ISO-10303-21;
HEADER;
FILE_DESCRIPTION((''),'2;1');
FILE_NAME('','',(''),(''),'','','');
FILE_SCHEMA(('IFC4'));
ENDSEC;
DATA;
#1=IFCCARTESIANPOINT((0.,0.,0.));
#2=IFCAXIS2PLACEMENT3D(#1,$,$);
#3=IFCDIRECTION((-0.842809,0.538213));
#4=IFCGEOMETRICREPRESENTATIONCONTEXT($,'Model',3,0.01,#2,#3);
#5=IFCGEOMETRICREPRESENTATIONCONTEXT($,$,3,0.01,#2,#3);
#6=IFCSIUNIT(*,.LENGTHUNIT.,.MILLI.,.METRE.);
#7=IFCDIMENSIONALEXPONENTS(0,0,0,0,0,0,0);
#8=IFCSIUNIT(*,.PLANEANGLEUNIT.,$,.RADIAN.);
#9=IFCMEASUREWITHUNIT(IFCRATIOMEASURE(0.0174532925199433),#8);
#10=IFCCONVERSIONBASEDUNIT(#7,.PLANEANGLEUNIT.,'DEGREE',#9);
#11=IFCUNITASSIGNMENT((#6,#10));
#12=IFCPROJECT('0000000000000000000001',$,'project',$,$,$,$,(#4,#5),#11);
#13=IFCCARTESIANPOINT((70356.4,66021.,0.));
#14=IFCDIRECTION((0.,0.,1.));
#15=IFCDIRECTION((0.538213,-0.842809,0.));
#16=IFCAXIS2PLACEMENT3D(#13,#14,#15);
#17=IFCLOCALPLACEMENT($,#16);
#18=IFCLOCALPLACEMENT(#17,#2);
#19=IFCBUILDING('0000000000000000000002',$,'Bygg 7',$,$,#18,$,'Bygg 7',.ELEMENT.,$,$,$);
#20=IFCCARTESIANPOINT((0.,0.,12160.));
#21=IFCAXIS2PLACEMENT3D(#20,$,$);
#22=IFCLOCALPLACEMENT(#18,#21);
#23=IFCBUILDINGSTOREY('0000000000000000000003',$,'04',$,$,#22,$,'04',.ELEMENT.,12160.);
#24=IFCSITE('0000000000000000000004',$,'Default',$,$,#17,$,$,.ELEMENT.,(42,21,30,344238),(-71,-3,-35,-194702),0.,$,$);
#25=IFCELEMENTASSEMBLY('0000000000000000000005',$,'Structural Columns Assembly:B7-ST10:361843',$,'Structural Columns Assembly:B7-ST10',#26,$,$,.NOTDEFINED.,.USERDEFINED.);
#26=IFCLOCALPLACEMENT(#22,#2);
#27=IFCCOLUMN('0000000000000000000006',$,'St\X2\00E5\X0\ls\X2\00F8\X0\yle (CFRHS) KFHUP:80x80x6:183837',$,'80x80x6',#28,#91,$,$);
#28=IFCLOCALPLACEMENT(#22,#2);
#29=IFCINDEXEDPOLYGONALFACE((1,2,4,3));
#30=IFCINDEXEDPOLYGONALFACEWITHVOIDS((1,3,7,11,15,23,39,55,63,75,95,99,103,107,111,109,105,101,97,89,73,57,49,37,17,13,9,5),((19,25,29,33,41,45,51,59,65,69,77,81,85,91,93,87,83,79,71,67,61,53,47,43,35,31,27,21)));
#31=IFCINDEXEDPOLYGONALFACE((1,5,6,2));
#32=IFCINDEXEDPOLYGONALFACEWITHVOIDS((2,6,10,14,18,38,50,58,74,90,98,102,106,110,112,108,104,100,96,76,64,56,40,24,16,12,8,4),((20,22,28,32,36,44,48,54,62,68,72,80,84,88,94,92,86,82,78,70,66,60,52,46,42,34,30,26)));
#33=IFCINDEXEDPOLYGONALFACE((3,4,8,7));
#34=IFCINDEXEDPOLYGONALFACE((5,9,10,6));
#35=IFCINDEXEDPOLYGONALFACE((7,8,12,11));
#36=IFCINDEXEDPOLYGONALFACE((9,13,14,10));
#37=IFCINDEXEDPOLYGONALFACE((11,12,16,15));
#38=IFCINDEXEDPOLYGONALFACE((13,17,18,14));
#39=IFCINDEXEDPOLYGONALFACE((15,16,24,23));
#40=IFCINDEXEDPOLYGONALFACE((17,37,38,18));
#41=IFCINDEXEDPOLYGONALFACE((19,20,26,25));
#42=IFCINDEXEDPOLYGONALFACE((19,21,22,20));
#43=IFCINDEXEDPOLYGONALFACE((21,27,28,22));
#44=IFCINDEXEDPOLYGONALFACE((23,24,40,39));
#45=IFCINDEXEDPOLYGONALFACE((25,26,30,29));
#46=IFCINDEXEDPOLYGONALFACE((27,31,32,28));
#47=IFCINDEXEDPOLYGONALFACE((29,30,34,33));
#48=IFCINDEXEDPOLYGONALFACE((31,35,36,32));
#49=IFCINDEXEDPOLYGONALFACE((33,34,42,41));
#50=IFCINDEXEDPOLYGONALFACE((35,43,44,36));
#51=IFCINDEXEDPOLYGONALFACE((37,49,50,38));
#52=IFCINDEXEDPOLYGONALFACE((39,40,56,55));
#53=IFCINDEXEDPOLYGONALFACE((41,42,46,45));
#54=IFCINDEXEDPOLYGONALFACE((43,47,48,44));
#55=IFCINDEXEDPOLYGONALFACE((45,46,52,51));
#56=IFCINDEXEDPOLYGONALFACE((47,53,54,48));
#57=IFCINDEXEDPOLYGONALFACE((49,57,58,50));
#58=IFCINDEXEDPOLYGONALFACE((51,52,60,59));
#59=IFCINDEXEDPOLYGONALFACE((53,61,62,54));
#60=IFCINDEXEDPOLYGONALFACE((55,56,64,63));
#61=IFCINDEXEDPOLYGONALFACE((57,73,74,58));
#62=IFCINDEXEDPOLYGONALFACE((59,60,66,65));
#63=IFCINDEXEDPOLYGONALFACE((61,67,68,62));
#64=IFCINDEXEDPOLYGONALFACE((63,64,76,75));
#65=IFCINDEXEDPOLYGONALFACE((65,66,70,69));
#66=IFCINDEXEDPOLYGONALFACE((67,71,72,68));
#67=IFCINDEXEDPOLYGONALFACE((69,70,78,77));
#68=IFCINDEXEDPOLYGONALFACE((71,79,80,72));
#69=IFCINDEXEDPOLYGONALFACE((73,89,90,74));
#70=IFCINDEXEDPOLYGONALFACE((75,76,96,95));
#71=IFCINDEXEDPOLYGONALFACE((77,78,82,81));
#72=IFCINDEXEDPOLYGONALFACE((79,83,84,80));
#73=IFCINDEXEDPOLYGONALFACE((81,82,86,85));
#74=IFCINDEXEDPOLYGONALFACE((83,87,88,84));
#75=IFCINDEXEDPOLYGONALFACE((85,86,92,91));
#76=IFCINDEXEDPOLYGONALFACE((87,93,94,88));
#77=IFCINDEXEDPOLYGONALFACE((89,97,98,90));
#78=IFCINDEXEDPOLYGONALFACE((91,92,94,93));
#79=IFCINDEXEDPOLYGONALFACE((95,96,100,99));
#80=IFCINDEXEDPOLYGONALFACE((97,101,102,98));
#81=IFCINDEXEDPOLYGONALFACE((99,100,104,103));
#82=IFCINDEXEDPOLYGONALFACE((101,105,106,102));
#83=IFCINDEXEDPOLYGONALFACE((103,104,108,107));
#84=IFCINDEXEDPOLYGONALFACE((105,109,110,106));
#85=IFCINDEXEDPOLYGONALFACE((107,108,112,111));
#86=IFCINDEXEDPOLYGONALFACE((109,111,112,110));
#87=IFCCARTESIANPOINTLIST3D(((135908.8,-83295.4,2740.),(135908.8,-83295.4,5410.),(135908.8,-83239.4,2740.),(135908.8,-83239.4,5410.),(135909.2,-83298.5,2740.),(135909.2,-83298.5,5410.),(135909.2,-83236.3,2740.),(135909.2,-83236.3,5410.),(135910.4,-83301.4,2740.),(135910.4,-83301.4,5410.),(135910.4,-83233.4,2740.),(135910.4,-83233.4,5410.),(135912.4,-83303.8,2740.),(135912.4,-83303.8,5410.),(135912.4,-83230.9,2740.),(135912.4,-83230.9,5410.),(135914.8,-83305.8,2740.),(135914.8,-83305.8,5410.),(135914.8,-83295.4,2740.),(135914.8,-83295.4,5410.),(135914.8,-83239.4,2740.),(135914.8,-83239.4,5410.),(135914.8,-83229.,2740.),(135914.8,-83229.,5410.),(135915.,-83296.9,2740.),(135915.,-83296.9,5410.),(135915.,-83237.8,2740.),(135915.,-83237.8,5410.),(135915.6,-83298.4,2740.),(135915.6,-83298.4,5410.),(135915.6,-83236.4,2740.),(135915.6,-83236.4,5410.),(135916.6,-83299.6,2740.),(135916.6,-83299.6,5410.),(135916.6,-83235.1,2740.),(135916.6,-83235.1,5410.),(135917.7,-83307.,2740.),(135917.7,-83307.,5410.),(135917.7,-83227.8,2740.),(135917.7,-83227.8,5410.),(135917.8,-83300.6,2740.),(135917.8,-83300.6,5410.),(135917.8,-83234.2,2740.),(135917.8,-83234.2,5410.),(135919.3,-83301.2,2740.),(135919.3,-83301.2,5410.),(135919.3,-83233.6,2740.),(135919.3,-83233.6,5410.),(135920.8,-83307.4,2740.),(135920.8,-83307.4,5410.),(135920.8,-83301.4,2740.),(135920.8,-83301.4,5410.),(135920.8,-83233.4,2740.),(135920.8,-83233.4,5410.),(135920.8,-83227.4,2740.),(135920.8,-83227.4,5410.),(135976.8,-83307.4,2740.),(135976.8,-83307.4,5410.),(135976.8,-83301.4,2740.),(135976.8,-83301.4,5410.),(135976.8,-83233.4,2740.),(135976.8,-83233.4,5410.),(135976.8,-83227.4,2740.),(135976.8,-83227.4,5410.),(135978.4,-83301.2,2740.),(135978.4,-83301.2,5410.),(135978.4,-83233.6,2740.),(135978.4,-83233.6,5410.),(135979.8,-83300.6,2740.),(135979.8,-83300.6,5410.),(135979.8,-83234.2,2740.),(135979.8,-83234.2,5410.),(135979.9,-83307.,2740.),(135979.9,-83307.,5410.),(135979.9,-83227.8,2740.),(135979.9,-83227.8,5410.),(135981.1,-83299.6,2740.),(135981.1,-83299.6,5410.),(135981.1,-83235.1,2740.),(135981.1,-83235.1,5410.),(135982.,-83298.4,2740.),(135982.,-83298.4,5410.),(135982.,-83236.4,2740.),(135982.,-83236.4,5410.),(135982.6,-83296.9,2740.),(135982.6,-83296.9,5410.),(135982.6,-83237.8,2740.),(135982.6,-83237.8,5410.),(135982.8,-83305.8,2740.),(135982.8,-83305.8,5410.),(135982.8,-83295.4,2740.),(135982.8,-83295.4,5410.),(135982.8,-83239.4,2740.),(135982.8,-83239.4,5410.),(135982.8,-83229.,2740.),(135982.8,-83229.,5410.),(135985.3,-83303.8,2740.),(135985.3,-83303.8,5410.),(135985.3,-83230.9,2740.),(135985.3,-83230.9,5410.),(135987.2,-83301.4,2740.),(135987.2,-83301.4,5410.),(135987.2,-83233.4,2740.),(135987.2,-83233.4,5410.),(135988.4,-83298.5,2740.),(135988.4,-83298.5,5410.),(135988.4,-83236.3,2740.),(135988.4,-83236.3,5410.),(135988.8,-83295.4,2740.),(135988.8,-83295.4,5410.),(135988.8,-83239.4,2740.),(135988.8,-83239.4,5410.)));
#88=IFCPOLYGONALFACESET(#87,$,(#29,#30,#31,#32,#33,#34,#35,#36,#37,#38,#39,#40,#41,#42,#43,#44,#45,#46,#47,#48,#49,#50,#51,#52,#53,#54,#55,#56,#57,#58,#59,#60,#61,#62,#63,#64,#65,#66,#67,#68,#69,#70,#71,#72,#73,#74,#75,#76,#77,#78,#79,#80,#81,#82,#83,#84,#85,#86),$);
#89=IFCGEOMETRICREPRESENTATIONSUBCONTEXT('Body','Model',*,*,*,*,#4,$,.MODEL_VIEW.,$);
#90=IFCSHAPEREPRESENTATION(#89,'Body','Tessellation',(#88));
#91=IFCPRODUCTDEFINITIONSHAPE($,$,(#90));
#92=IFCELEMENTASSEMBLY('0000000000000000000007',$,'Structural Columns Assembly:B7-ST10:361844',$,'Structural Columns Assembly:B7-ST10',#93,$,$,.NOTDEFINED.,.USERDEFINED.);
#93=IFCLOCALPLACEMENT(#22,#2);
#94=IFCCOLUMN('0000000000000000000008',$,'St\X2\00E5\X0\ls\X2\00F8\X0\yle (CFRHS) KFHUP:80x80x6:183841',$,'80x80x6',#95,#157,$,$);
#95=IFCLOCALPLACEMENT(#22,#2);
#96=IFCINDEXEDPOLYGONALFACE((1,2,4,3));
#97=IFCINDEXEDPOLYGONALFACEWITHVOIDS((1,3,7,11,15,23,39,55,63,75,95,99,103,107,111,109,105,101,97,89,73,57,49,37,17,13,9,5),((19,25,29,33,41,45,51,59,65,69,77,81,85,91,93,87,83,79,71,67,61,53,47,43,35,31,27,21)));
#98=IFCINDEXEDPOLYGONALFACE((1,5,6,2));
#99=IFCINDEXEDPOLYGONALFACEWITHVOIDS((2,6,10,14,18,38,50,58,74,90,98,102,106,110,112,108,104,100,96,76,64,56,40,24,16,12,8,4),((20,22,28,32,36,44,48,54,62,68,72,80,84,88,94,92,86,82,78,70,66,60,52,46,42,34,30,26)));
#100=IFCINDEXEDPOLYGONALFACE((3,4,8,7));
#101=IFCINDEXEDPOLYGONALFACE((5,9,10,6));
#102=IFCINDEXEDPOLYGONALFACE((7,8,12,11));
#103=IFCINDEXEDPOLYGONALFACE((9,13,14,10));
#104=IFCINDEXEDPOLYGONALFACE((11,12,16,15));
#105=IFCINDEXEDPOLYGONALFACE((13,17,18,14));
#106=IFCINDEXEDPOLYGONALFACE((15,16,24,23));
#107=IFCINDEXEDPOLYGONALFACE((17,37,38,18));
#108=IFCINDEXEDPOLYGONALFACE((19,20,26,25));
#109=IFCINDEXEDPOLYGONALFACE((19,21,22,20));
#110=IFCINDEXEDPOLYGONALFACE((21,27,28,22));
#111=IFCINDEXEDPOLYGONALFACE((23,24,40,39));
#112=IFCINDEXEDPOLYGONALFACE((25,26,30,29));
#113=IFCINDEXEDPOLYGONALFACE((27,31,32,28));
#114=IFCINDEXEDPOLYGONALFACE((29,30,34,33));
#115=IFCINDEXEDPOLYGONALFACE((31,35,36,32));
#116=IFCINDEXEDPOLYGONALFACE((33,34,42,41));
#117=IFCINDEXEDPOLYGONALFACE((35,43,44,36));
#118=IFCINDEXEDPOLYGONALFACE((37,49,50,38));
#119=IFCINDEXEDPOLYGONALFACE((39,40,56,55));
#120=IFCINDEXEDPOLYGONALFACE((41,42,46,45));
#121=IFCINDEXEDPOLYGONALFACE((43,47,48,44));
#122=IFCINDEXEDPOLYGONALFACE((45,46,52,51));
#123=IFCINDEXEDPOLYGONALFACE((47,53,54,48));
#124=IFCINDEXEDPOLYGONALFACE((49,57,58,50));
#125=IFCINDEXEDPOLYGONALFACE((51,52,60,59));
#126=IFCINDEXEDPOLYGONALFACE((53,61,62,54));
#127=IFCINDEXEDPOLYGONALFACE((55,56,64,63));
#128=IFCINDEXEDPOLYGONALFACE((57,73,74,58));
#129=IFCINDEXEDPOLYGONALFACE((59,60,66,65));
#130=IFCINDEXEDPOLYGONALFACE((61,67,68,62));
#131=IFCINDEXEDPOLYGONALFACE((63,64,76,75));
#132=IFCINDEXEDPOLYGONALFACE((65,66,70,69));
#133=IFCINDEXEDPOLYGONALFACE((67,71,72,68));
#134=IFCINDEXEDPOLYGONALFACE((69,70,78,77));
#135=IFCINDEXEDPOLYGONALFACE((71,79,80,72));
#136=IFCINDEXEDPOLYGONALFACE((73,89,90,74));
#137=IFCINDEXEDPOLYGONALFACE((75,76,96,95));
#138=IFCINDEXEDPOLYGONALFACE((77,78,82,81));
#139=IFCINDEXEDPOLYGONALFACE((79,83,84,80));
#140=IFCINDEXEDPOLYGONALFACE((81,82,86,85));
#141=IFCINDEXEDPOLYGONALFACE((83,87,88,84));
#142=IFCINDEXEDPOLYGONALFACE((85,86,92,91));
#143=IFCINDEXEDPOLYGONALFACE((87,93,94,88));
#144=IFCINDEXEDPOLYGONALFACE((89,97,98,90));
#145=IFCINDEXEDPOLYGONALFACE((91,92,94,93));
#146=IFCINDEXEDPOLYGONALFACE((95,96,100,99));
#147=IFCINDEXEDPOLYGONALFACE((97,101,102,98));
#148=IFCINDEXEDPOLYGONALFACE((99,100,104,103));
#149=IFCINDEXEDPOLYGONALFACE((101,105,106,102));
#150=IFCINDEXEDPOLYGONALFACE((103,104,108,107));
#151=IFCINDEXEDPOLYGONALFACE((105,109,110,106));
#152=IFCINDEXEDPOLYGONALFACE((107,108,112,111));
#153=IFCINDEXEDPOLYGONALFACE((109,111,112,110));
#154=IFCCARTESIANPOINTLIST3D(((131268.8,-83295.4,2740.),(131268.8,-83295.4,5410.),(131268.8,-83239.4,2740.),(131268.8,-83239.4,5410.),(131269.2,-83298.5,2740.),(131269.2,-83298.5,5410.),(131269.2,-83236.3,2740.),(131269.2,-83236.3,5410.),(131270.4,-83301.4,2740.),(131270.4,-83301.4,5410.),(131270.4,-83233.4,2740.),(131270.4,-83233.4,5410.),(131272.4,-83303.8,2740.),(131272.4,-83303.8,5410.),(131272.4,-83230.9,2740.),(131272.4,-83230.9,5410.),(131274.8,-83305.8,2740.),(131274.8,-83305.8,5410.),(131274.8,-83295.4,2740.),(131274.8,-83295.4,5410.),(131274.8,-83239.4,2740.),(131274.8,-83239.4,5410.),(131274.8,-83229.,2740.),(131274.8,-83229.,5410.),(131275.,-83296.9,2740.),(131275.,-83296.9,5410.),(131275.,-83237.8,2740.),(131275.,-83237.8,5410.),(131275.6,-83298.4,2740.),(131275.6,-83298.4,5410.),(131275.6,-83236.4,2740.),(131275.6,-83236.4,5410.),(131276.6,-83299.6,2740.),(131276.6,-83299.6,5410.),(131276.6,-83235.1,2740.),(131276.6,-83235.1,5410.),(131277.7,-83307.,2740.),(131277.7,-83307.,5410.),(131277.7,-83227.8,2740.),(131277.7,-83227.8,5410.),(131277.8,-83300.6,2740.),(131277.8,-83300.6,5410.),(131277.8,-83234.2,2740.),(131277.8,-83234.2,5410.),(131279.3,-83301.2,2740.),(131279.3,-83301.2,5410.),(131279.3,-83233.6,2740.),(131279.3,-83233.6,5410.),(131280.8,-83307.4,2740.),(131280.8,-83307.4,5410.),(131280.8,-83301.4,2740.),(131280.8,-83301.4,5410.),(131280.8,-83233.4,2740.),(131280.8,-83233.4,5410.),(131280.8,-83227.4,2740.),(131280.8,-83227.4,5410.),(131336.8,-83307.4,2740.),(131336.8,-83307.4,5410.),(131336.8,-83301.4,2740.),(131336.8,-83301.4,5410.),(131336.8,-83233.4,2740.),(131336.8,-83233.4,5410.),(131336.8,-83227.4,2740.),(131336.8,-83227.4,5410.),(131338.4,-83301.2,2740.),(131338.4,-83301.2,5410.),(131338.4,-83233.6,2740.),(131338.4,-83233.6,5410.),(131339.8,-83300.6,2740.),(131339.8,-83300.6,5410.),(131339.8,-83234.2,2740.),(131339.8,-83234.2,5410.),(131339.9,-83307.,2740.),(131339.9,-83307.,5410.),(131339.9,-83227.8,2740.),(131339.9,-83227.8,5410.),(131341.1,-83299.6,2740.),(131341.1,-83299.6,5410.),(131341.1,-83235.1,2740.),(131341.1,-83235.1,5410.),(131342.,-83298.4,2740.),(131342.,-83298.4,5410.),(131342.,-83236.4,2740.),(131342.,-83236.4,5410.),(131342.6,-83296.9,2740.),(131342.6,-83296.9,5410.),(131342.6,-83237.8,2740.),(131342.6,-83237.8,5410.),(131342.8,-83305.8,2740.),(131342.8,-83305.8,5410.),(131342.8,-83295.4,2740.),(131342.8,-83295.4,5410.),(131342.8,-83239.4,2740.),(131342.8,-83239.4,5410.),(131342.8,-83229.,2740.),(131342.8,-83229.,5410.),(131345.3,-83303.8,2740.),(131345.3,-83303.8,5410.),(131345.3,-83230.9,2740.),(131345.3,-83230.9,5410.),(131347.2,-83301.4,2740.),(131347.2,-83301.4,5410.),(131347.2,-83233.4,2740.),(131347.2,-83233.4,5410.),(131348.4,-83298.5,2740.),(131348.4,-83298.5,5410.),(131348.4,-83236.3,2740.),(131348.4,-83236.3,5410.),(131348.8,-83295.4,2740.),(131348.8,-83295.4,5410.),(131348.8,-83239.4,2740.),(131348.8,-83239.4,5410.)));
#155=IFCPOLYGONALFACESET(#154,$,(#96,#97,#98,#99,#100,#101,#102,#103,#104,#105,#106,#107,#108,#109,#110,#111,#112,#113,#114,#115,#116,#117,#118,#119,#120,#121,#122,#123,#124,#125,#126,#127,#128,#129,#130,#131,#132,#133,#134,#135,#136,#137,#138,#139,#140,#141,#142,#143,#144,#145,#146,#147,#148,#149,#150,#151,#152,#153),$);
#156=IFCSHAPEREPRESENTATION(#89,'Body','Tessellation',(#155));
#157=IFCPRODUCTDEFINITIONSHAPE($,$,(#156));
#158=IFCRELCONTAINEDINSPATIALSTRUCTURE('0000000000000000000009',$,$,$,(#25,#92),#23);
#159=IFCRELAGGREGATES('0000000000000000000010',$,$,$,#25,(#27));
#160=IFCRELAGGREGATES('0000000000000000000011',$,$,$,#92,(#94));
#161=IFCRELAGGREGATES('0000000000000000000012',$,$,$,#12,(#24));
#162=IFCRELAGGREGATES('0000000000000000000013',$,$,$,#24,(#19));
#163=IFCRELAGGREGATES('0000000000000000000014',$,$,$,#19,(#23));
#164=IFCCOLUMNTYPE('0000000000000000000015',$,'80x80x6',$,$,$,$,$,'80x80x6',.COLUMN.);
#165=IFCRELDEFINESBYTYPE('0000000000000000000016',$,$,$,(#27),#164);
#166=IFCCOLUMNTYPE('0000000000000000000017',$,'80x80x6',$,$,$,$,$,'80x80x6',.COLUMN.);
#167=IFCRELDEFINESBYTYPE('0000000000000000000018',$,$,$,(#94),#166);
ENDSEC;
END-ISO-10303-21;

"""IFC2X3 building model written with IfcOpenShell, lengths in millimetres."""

from ifc_helpers import new_model, entity, si_unit, converted_unit, direction, frame, frame_2d, origin, place, context, subcontext, project, spatial, polyline, circle_curve, parameter, trimmed, segment, composite_curve, outline, extrude, source, transform, mapped, type_object, type_shapes, element, aggregate, save


model = new_model("IFC2X3")

# Units and contexts
model_context = context("Model", 3, precision=0.01, world=origin(), true_north=direction((-0.842809, 0.538213)))
context_of_model = context(None, 3, precision=0.01, world=origin(), true_north=direction((-0.842809, 0.538213)))
body_context = subcontext(model_context, "Body", "Model", "MODEL_VIEW")
ifc_project = project(units=[si_unit("LENGTHUNIT", "METRE", prefix="MILLI"), converted_unit("PLANEANGLEUNIT", "DEGREE", entity("IfcRatioMeasure", 0.0174532925199433), si_unit("PLANEANGLEUNIT", "RADIAN"), dimensions=[0, 0, 0, 0, 0, 0, 0])], contexts=[model_context, context_of_model])

# Site, building, storey
site_placement = place(None, frame((70356.4, 66021.0, 0.0), z_axis=(0.0, 0.0, 1.0), x_axis=(0.538213, -0.842809, 0.0)))
site = spatial("IfcSite", under=ifc_project, at=site_placement, Name="Default", CompositionType="ELEMENT", RefLatitude=(42, 21, 30, 344238), RefLongitude=(-71, -3, -35, -194702), RefElevation=0.0)
building_placement = place(site_placement, origin())
building = spatial("IfcBuilding", under=site, at=building_placement, Name="Bygg 7", LongName="Bygg 7", CompositionType="ELEMENT")
storey_placement = place(building_placement, frame((0.0, 0.0, 12160.0)))
storey = spatial("IfcBuildingStorey", under=building, at=storey_placement, Name="04", LongName="04", CompositionType="ELEMENT", Elevation=12160.0)

# Element assemblies, columns
assembly_1_placement = place(storey_placement, origin())
assembly_1 = element("IfcElementAssembly", 1, at=assembly_1_placement, inside=storey, Name="Structural Columns Assembly:B7-ST10:361843", ObjectType="Structural Columns Assembly:B7-ST10", AssemblyPlace="NOTDEFINED", PredefinedType="USERDEFINED")
column_type_1 = type_object("IfcColumnType", Name="80x80x6", ElementType="80x80x6", PredefinedType="COLUMN")
shared_shape_1 = source(origin(), body_context, "Body", "SweptSolid", [
    extrude(outline(composite_curve([segment(trimmed(circle_curve(frame_2d((-28.0, 28.0), x_axis=(1.0, 0.0)), 12.0), [parameter(90.0)], [parameter(180.0)], True, "PARAMETER"), True, "CONTINUOUS"), segment(polyline([(-40.0, 28.0), (-40.0, -28.0)]), True, "CONTINUOUS"), segment(trimmed(circle_curve(frame_2d((-28.0, -28.0), x_axis=(1.0, 0.0)), 12.0), [parameter(180.0)], [parameter(270.0)], True, "PARAMETER"), True, "CONTINUOUS"), segment(polyline([(-28.0, -40.0), (28.0, -40.0)]), True, "CONTINUOUS"), segment(trimmed(circle_curve(frame_2d((28.0, -28.0), x_axis=(1.0, 0.0)), 12.0), [parameter(270.0)], [parameter(0.0)], True, "PARAMETER"), True, "CONTINUOUS"), segment(polyline([(40.0, -28.0), (40.0, 28.0)]), True, "CONTINUOUS"), segment(trimmed(circle_curve(frame_2d((28.0, 28.0), x_axis=(1.0, 0.0)), 12.0), [parameter(0.0)], [parameter(90.0)], True, "PARAMETER"), True, "CONTINUOUS"), segment(polyline([(28.0, 40.0), (-28.0, 40.0)]), True, "CONTINUOUS")], self_intersect=False), holes=[composite_curve([segment(polyline([(-28.0, 34.0), (28.0, 34.0)]), True, "CONTINUOUS"), segment(trimmed(circle_curve(frame_2d((28.0, 28.0), x_axis=(1.0, 0.0)), 6.0), [parameter(360.0)], [parameter(90.0)], True, "PARAMETER"), False, "CONTINUOUS"), segment(polyline([(34.0, 28.0), (34.0, -28.0)]), True, "CONTINUOUS"), segment(trimmed(circle_curve(frame_2d((28.0, -28.0), x_axis=(1.0, 0.0)), 6.0), [parameter(270.0)], [parameter(360.0)], True, "PARAMETER"), False, "CONTINUOUS"), segment(polyline([(28.0, -34.0), (-28.0, -34.0)]), True, "CONTINUOUS"), segment(trimmed(circle_curve(frame_2d((-28.0, -28.0), x_axis=(1.0, 0.0)), 6.0), [parameter(180.0)], [parameter(270.0)], True, "PARAMETER"), False, "CONTINUOUS"), segment(polyline([(-34.0, -28.0), (-34.0, 28.0)]), True, "CONTINUOUS"), segment(trimmed(circle_curve(frame_2d((-28.0, 28.0), x_axis=(1.0, 0.0)), 6.0), [parameter(90.0)], [parameter(180.0)], True, "PARAMETER"), False, "CONTINUOUS")], self_intersect=False)]), frame((41.6, 41.6, 0.0), z_axis=(0.0, 0.0, 1.0), x_axis=(0.0, -1.0, 0.0)), (0.0, 0.0, 1.0), 2670.0),
])
type_shapes(column_type_1, [shared_shape_1])
column_1_placement = place(assembly_1_placement, frame((135907.2, -83309.0, 2740.0)))
column_1 = element("IfcColumn", 2, at=column_1_placement, type_object=column_type_1, Name="Stålsøyle (CFRHS) KFHUP:80x80x6:183837", ObjectType="80x80x6", context=body_context, shape_type="MappedRepresentation", body=[
    mapped(shared_shape_1, transform((0.0, 0.0, 0.0), scale=1.0)),
])
aggregate(assembly_1, [column_1])
assembly_2_placement = place(storey_placement, origin())
assembly_2 = element("IfcElementAssembly", 3, at=assembly_2_placement, inside=storey, Name="Structural Columns Assembly:B7-ST10:361844", ObjectType="Structural Columns Assembly:B7-ST10", AssemblyPlace="NOTDEFINED", PredefinedType="USERDEFINED")
column_type_2 = type_object("IfcColumnType", Name="80x80x6", ElementType="80x80x6", PredefinedType="COLUMN")
shared_shape_2 = source(origin(), body_context, "Body", "SweptSolid", [
    extrude(outline(composite_curve([segment(trimmed(circle_curve(frame_2d((-28.0, 28.0), x_axis=(1.0, 0.0)), 12.0), [parameter(90.0)], [parameter(180.0)], True, "PARAMETER"), True, "CONTINUOUS"), segment(polyline([(-40.0, 28.0), (-40.0, -28.0)]), True, "CONTINUOUS"), segment(trimmed(circle_curve(frame_2d((-28.0, -28.0), x_axis=(1.0, 0.0)), 12.0), [parameter(180.0)], [parameter(270.0)], True, "PARAMETER"), True, "CONTINUOUS"), segment(polyline([(-28.0, -40.0), (28.0, -40.0)]), True, "CONTINUOUS"), segment(trimmed(circle_curve(frame_2d((28.0, -28.0), x_axis=(1.0, 0.0)), 12.0), [parameter(270.0)], [parameter(0.0)], True, "PARAMETER"), True, "CONTINUOUS"), segment(polyline([(40.0, -28.0), (40.0, 28.0)]), True, "CONTINUOUS"), segment(trimmed(circle_curve(frame_2d((28.0, 28.0), x_axis=(1.0, 0.0)), 12.0), [parameter(0.0)], [parameter(90.0)], True, "PARAMETER"), True, "CONTINUOUS"), segment(polyline([(28.0, 40.0), (-28.0, 40.0)]), True, "CONTINUOUS")], self_intersect=False), holes=[composite_curve([segment(polyline([(-28.0, 34.0), (28.0, 34.0)]), True, "CONTINUOUS"), segment(trimmed(circle_curve(frame_2d((28.0, 28.0), x_axis=(1.0, 0.0)), 6.0), [parameter(360.0)], [parameter(90.0)], True, "PARAMETER"), False, "CONTINUOUS"), segment(polyline([(34.0, 28.0), (34.0, -28.0)]), True, "CONTINUOUS"), segment(trimmed(circle_curve(frame_2d((28.0, -28.0), x_axis=(1.0, 0.0)), 6.0), [parameter(270.0)], [parameter(360.0)], True, "PARAMETER"), False, "CONTINUOUS"), segment(polyline([(28.0, -34.0), (-28.0, -34.0)]), True, "CONTINUOUS"), segment(trimmed(circle_curve(frame_2d((-28.0, -28.0), x_axis=(1.0, 0.0)), 6.0), [parameter(180.0)], [parameter(270.0)], True, "PARAMETER"), False, "CONTINUOUS"), segment(polyline([(-34.0, -28.0), (-34.0, 28.0)]), True, "CONTINUOUS"), segment(trimmed(circle_curve(frame_2d((-28.0, 28.0), x_axis=(1.0, 0.0)), 6.0), [parameter(90.0)], [parameter(180.0)], True, "PARAMETER"), False, "CONTINUOUS")], self_intersect=False)]), frame((41.6, 41.6, 0.0), z_axis=(0.0, 0.0, 1.0), x_axis=(0.0, -1.0, 0.0)), (0.0, 0.0, 1.0), 2670.0),
])
type_shapes(column_type_2, [shared_shape_2])
column_2_placement = place(assembly_2_placement, frame((131267.2, -83309.0, 2740.0)))
column_2 = element("IfcColumn", 4, at=column_2_placement, type_object=column_type_2, Name="Stålsøyle (CFRHS) KFHUP:80x80x6:183841", ObjectType="80x80x6", context=body_context, shape_type="MappedRepresentation", body=[
    mapped(shared_shape_2, transform((0.0, 0.0, 0.0), scale=1.0)),
])
aggregate(assembly_2, [column_2])

save(model, "model.ifc")
